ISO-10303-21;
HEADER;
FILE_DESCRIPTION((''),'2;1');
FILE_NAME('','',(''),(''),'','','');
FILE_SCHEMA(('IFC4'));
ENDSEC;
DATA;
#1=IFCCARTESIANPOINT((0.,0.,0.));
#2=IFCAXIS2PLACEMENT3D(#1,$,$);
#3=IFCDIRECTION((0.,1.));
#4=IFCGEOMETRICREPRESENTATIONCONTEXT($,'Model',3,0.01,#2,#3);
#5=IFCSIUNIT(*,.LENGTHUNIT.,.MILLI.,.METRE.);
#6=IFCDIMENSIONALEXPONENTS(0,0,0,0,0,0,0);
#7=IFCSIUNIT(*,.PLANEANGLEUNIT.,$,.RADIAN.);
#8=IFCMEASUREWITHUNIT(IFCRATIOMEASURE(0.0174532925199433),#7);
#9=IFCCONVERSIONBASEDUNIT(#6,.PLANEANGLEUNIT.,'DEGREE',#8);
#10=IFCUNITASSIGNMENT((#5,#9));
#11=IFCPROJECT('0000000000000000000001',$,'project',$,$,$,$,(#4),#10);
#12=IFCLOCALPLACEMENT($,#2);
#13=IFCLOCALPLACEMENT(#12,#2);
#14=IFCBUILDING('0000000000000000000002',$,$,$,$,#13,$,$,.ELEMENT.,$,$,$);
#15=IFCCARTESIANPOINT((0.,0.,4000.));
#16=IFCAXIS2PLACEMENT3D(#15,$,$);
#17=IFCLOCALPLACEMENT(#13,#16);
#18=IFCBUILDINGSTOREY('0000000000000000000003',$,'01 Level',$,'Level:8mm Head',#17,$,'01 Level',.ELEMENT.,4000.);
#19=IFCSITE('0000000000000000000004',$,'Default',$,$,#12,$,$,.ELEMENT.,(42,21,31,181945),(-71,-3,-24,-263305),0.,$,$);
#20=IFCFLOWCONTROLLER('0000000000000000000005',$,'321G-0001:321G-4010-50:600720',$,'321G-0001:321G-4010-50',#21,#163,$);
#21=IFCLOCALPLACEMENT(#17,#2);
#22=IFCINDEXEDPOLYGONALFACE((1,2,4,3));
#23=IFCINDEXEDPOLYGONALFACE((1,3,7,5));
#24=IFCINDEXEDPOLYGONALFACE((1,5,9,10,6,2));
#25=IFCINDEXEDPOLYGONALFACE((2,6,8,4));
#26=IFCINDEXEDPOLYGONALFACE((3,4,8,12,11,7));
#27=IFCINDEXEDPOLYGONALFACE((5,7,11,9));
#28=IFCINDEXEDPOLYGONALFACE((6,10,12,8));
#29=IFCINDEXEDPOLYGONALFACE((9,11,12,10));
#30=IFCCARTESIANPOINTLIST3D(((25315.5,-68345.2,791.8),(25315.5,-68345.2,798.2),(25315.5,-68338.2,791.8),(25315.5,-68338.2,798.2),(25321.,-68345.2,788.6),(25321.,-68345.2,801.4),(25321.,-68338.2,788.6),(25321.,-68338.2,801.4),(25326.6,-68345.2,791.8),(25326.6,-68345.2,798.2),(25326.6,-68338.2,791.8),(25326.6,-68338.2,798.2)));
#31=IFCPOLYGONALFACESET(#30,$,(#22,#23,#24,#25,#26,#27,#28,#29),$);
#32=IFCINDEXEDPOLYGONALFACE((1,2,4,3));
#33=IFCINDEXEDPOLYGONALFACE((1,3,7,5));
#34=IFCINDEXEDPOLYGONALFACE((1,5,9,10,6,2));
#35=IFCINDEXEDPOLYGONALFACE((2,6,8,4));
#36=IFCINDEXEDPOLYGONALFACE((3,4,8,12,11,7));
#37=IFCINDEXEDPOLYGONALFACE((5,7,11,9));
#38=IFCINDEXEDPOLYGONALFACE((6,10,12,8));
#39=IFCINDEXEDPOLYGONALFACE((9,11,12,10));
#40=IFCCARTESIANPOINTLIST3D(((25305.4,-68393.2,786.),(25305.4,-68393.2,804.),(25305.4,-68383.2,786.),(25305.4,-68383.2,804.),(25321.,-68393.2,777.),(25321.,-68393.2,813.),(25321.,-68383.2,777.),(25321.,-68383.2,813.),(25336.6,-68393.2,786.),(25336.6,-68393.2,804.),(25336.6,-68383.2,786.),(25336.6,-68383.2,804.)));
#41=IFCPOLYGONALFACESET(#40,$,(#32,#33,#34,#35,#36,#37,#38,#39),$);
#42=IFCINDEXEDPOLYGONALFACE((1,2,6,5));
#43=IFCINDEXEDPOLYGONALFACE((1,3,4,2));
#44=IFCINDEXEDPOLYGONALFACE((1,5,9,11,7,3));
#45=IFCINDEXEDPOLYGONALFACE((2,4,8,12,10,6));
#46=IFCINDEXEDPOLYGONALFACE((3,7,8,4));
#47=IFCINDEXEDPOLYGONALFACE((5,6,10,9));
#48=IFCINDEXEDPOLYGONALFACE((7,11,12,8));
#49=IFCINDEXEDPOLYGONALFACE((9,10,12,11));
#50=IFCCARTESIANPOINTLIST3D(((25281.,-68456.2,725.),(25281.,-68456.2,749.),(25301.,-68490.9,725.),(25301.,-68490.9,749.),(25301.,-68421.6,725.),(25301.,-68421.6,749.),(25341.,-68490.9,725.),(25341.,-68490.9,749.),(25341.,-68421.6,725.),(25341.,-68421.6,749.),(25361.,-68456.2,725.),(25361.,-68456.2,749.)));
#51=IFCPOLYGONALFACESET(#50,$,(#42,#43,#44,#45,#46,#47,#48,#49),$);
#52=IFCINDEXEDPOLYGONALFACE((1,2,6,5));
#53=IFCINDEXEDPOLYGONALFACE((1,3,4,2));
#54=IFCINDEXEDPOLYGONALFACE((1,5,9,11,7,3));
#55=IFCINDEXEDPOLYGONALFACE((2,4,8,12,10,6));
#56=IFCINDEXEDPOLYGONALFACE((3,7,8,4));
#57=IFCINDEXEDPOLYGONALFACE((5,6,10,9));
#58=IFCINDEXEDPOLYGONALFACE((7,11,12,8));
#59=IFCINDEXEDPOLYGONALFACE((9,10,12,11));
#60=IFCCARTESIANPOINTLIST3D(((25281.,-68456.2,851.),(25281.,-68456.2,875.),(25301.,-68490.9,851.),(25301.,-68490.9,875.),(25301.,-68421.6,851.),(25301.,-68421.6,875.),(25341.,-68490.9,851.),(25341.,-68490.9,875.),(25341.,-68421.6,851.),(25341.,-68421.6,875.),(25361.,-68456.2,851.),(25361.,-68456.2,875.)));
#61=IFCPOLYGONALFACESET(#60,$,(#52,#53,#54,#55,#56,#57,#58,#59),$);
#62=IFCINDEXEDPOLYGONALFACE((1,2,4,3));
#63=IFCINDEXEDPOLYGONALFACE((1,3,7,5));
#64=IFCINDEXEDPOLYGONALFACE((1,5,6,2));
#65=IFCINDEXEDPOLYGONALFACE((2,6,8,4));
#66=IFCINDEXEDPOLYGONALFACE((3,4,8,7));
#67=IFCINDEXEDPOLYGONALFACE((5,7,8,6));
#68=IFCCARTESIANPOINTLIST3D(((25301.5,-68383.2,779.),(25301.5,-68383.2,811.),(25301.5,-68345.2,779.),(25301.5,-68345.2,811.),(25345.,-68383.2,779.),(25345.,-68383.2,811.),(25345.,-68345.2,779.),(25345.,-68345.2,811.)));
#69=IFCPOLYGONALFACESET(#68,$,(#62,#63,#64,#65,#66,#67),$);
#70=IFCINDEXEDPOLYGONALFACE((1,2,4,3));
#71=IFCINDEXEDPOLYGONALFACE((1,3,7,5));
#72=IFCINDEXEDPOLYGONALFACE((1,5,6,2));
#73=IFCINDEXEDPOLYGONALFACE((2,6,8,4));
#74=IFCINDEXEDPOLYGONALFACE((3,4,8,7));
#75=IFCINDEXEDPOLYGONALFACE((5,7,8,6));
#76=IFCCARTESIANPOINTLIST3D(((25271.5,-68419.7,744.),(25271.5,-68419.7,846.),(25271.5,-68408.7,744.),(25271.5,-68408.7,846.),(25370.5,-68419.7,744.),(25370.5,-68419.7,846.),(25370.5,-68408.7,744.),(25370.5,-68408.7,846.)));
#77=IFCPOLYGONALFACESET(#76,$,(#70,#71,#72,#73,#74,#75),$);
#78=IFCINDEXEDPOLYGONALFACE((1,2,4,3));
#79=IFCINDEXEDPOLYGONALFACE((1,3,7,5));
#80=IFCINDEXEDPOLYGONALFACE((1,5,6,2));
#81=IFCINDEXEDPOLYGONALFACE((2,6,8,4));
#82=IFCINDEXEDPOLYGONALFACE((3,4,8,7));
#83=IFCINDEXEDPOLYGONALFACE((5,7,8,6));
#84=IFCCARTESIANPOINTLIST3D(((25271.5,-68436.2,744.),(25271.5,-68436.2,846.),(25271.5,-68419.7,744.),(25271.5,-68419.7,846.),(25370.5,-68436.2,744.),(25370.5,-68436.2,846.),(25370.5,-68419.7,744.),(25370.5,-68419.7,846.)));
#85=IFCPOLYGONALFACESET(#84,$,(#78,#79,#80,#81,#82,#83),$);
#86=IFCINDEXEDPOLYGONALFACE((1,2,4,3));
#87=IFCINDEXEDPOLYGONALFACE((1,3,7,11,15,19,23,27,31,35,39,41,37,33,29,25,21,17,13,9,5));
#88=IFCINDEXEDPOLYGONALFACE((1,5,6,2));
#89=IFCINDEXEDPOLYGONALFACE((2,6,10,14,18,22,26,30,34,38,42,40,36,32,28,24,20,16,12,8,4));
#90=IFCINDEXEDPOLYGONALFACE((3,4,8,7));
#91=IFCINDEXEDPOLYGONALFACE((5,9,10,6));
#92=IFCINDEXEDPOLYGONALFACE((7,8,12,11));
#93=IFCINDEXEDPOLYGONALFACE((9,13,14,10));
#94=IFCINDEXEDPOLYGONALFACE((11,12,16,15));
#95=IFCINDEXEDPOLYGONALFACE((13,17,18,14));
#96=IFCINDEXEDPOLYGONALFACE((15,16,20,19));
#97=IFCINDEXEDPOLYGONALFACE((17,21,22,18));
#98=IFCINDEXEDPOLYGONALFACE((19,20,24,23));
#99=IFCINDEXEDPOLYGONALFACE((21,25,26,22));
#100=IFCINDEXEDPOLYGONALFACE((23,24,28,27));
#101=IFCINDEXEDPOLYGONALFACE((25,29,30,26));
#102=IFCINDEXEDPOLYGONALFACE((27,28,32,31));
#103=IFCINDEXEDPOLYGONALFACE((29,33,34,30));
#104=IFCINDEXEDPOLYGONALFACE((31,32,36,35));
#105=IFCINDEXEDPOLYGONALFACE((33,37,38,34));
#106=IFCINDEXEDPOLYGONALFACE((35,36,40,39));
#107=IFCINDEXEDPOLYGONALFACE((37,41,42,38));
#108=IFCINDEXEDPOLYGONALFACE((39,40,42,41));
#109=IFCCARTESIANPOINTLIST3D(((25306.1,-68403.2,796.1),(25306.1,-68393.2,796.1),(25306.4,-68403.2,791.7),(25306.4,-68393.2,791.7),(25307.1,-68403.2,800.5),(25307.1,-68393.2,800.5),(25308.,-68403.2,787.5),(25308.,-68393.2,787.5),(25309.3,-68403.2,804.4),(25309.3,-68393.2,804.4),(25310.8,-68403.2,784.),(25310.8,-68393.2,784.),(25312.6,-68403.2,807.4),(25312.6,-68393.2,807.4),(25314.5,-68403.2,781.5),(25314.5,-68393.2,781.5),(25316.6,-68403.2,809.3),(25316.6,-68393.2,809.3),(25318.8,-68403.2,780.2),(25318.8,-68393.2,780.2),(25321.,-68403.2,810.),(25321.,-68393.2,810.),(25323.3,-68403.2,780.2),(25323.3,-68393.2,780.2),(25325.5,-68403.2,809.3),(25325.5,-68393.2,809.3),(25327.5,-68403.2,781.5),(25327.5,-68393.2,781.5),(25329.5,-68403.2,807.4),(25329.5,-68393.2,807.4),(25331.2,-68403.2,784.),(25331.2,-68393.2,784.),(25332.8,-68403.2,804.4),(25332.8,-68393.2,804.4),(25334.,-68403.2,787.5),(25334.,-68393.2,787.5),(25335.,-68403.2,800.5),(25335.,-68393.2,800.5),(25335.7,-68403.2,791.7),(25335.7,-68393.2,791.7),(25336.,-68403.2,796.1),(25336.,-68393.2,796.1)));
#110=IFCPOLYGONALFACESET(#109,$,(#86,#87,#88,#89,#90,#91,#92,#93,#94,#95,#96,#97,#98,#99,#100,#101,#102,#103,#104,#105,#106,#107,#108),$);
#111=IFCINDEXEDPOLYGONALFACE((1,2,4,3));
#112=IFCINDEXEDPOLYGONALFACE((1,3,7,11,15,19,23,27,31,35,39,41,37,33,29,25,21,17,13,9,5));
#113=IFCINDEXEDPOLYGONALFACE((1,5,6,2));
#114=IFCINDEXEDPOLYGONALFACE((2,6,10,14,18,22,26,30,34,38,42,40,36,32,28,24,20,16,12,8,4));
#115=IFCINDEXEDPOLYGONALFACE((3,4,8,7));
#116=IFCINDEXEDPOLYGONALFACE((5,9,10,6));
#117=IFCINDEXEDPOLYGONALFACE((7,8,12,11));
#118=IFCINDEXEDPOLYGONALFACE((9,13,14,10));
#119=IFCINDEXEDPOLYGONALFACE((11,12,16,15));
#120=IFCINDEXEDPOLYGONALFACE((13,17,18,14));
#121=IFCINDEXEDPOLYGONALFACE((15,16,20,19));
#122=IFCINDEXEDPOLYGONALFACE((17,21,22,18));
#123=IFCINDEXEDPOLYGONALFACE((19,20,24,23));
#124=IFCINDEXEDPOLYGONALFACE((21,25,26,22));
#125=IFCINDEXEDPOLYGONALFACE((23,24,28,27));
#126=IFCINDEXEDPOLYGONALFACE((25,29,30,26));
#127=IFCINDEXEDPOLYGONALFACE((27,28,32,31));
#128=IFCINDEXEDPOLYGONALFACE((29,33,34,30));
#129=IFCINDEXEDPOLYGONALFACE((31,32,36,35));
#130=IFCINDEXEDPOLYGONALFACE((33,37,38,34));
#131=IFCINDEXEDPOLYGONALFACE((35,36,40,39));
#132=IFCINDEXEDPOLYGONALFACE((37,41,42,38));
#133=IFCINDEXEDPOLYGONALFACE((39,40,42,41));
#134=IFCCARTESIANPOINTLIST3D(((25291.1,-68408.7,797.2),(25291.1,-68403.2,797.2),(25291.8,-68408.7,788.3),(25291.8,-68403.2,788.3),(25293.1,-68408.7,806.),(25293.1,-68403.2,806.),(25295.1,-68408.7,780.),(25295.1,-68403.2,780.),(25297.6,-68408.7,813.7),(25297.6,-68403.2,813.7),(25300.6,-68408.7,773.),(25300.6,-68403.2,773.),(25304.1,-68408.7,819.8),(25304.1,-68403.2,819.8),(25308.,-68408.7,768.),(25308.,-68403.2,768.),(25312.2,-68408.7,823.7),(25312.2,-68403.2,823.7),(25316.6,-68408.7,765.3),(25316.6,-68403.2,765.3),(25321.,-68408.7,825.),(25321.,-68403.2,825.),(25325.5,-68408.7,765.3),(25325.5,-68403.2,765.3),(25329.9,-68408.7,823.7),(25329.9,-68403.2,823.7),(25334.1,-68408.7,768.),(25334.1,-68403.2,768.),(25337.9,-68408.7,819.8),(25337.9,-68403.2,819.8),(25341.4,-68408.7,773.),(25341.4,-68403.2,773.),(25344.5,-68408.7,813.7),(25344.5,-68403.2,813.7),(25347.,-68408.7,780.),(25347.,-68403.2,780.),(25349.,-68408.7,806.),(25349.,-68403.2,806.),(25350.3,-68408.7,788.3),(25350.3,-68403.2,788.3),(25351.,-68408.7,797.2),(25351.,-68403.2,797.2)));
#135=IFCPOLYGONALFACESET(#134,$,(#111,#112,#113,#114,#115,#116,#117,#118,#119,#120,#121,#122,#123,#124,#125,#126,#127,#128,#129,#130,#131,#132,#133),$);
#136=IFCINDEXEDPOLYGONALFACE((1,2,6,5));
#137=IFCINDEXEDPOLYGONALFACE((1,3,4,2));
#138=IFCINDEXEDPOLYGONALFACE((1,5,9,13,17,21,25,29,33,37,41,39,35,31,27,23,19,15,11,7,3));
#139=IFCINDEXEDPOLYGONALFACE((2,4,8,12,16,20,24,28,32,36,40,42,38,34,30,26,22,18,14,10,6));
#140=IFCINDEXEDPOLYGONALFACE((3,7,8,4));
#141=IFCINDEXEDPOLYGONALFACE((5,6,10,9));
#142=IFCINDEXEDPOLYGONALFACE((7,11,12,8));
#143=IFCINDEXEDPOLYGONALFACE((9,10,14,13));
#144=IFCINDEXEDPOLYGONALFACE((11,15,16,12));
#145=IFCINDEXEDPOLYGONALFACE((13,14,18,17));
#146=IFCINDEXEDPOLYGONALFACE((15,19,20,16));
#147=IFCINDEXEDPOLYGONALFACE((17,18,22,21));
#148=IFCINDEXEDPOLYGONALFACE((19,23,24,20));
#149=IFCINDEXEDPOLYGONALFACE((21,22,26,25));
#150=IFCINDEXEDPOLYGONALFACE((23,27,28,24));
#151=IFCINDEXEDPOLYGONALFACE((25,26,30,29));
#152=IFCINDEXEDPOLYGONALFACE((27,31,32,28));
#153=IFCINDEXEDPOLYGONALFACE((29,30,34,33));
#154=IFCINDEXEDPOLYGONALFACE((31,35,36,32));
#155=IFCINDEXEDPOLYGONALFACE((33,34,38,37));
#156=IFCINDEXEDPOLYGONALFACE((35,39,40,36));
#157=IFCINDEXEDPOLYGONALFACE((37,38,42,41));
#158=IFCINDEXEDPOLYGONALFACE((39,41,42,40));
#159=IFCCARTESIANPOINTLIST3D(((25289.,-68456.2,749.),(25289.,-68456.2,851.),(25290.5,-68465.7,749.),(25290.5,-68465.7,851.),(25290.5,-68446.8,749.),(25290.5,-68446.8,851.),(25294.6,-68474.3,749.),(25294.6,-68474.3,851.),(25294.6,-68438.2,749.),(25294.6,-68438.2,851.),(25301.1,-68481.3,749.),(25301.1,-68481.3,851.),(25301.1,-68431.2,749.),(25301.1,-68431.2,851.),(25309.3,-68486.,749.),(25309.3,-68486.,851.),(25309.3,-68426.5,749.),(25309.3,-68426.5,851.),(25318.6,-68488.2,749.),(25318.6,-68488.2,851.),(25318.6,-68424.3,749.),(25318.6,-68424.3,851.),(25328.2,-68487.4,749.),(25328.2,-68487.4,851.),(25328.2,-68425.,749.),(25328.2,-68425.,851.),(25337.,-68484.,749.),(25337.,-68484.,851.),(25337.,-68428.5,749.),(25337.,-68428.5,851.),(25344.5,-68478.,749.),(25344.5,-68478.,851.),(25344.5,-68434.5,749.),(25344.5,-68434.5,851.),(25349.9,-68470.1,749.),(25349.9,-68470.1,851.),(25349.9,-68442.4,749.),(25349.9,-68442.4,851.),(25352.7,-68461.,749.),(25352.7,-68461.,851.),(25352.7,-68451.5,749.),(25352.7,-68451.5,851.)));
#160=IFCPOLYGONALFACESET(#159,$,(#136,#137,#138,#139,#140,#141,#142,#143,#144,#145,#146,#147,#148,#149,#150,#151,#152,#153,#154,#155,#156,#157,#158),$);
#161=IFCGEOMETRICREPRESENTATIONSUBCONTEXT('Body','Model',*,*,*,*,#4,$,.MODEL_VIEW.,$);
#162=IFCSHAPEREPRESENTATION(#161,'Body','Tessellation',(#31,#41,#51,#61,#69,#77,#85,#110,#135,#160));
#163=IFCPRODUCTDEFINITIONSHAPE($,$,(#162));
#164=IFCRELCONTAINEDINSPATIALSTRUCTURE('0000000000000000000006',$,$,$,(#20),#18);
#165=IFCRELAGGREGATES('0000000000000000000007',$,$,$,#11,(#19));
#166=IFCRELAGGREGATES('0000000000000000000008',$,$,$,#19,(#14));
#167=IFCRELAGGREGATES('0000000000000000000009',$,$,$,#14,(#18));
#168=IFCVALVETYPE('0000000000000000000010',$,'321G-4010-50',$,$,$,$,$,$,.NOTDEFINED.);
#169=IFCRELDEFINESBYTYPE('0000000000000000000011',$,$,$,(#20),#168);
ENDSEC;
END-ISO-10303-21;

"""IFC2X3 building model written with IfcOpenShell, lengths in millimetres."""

from ifc_helpers import new_model, entity, si_unit, converted_unit, direction, frame, frame_2d, origin, origin_2d_with_axis, place, context, subcontext, project, spatial, polyline, rectangle, circle, outline, extrude, source, transform, mapped, type_object, type_shapes, element, save


model = new_model("IFC2X3")

# Units and contexts
model_context = context("Model", 3, precision=0.01, world=origin(), true_north=direction((0.0, 1.0)))
body_context = subcontext(model_context, "Body", "Model", "MODEL_VIEW")
ifc_project = project(units=[si_unit("LENGTHUNIT", "METRE", prefix="MILLI"), converted_unit("PLANEANGLEUNIT", "DEGREE", entity("IfcRatioMeasure", 0.0174532925199433), si_unit("PLANEANGLEUNIT", "RADIAN"), dimensions=[0, 0, 0, 0, 0, 0, 0])], contexts=[model_context])

# Site, building, storey
site_placement = place(None, origin())
site = spatial("IfcSite", under=ifc_project, at=site_placement, Name="Default", CompositionType="ELEMENT", RefLatitude=(42, 21, 31, 181945), RefLongitude=(-71, -3, -24, -263305), RefElevation=0.0)
building_placement = place(site_placement, origin())
building = spatial("IfcBuilding", under=site, at=building_placement, CompositionType="ELEMENT")
storey_placement = place(building_placement, frame((0.0, 0.0, 4000.0)))
storey = spatial("IfcBuildingStorey", under=building, at=storey_placement, Name="01 Level", ObjectType="Level:8mm Head", LongName="01 Level", CompositionType="ELEMENT", Elevation=4000.0)

# Flow controller
valve_type_1 = type_object("IfcValveType", Name="321G-4010-50", PredefinedType="NOTDEFINED")
shared_shape_1 = source(origin(), body_context, "Body", "SweptSolid", [
    extrude(outline(polyline([(-3.2, -5.5), (3.2, -5.5), (6.4, 0.0), (3.2, 5.5), (-3.2, 5.5), (-6.4, 0.0), (-3.2, -5.5)])), frame((-5.0, 0.0, 111.0), z_axis=(0.0, 0.0, 1.0), x_axis=(0.5, 0.866025, 0.0)), (0.0, 0.0, 1.0), 7.0),
    extrude(outline(polyline([(-9.0, -15.6), (9.0, -15.6), (18.0, 0.0), (9.0, 15.6), (-9.0, 15.6), (-18.0, 0.0), (-9.0, -15.6)])), frame((-5.0, 0.0, 63.0), z_axis=(0.0, 0.0, 1.0), x_axis=(0.5, 0.866025, 0.0)), (0.0, 0.0, 1.0), 10.0),
    extrude(outline(polyline([(-20.0, -34.6), (20.0, -34.6), (40.0, 0.0), (20.0, 34.6), (-20.0, 34.6), (-40.0, 0.0), (-20.0, -34.6)])), frame((-75.0, 0.0, 0.0), z_axis=(1.0, 0.0, 0.0), x_axis=(0.0, -0.5, -0.866025)), (0.0, 0.0, 1.0), 24.0),
    extrude(outline(polyline([(-20.0, -34.6), (20.0, -34.6), (40.0, 0.0), (20.0, 34.6), (-20.0, 34.6), (-40.0, 0.0), (-20.0, -34.6)])), frame((51.0, 0.0, 0.0), z_axis=(1.0, 0.0, 0.0), x_axis=(0.0, -0.5, -0.866025)), (0.0, 0.0, 1.0), 24.0),
    extrude(rectangle(XDim=43.5, YDim=32.0, at=frame_2d((0.0, 0.0), x_axis=(1.0, 0.0))), frame((-5.0, 2.2, 73.0), z_axis=(0.0, 0.0, 1.0), x_axis=(0.0, -1.0, 0.0)), (0.0, 0.0, 1.0), 38.0),
    extrude(rectangle(XDim=99.0, YDim=102.0, at=origin_2d_with_axis()), frame((-5.0, 0.0, 36.5), z_axis=(0.0, 0.0, 1.0), x_axis=(0.0, -1.0, 0.0)), (0.0, 0.0, 1.0), 11.0),
    extrude(rectangle(XDim=99.0, YDim=102.0, at=origin_2d_with_axis()), frame((-5.0, 0.0, 20.0), z_axis=(0.0, 0.0, 1.0), x_axis=(0.0, -1.0, 0.0)), (0.0, 0.0, 1.0), 16.5),
    extrude(circle(Radius=15.0, at=frame_2d((0.0, 0.0), x_axis=(1.0, 0.0))), frame((-5.0, 0.0, 53.0)), (0.0, 0.0, 1.0), 10.0),
    extrude(circle(Radius=30.0, at=frame_2d((0.0, 0.0), x_axis=(1.0, 0.0))), frame((-5.0, 0.0, 47.5)), (0.0, 0.0, 1.0), 5.5),
    extrude(circle(Radius=32.0, at=frame_2d((0.0, 0.0), x_axis=(1.0, 0.0))), frame((-51.0, 0.0, 0.0), z_axis=(1.0, 0.0, 0.0), x_axis=(0.0, -1.0, 0.0)), (0.0, 0.0, 1.0), 102.0),
])
type_shapes(valve_type_1, [shared_shape_1])
flow_controller_1_placement = place(storey_placement, frame((25321.0, -68456.2, 800.0), z_axis=(0.0, 1.0, 0.0), x_axis=(0.0, 0.0, 1.0)))
element("IfcFlowController", 1, at=flow_controller_1_placement, inside=storey, type_object=valve_type_1, Name="321G-0001:321G-4010-50:600720", ObjectType="321G-0001:321G-4010-50", context=body_context, shape_type="MappedRepresentation", body=[
    mapped(shared_shape_1, transform((0.0, 0.0, 0.0), scale=1.0)),
])

save(model, "model.ifc")
